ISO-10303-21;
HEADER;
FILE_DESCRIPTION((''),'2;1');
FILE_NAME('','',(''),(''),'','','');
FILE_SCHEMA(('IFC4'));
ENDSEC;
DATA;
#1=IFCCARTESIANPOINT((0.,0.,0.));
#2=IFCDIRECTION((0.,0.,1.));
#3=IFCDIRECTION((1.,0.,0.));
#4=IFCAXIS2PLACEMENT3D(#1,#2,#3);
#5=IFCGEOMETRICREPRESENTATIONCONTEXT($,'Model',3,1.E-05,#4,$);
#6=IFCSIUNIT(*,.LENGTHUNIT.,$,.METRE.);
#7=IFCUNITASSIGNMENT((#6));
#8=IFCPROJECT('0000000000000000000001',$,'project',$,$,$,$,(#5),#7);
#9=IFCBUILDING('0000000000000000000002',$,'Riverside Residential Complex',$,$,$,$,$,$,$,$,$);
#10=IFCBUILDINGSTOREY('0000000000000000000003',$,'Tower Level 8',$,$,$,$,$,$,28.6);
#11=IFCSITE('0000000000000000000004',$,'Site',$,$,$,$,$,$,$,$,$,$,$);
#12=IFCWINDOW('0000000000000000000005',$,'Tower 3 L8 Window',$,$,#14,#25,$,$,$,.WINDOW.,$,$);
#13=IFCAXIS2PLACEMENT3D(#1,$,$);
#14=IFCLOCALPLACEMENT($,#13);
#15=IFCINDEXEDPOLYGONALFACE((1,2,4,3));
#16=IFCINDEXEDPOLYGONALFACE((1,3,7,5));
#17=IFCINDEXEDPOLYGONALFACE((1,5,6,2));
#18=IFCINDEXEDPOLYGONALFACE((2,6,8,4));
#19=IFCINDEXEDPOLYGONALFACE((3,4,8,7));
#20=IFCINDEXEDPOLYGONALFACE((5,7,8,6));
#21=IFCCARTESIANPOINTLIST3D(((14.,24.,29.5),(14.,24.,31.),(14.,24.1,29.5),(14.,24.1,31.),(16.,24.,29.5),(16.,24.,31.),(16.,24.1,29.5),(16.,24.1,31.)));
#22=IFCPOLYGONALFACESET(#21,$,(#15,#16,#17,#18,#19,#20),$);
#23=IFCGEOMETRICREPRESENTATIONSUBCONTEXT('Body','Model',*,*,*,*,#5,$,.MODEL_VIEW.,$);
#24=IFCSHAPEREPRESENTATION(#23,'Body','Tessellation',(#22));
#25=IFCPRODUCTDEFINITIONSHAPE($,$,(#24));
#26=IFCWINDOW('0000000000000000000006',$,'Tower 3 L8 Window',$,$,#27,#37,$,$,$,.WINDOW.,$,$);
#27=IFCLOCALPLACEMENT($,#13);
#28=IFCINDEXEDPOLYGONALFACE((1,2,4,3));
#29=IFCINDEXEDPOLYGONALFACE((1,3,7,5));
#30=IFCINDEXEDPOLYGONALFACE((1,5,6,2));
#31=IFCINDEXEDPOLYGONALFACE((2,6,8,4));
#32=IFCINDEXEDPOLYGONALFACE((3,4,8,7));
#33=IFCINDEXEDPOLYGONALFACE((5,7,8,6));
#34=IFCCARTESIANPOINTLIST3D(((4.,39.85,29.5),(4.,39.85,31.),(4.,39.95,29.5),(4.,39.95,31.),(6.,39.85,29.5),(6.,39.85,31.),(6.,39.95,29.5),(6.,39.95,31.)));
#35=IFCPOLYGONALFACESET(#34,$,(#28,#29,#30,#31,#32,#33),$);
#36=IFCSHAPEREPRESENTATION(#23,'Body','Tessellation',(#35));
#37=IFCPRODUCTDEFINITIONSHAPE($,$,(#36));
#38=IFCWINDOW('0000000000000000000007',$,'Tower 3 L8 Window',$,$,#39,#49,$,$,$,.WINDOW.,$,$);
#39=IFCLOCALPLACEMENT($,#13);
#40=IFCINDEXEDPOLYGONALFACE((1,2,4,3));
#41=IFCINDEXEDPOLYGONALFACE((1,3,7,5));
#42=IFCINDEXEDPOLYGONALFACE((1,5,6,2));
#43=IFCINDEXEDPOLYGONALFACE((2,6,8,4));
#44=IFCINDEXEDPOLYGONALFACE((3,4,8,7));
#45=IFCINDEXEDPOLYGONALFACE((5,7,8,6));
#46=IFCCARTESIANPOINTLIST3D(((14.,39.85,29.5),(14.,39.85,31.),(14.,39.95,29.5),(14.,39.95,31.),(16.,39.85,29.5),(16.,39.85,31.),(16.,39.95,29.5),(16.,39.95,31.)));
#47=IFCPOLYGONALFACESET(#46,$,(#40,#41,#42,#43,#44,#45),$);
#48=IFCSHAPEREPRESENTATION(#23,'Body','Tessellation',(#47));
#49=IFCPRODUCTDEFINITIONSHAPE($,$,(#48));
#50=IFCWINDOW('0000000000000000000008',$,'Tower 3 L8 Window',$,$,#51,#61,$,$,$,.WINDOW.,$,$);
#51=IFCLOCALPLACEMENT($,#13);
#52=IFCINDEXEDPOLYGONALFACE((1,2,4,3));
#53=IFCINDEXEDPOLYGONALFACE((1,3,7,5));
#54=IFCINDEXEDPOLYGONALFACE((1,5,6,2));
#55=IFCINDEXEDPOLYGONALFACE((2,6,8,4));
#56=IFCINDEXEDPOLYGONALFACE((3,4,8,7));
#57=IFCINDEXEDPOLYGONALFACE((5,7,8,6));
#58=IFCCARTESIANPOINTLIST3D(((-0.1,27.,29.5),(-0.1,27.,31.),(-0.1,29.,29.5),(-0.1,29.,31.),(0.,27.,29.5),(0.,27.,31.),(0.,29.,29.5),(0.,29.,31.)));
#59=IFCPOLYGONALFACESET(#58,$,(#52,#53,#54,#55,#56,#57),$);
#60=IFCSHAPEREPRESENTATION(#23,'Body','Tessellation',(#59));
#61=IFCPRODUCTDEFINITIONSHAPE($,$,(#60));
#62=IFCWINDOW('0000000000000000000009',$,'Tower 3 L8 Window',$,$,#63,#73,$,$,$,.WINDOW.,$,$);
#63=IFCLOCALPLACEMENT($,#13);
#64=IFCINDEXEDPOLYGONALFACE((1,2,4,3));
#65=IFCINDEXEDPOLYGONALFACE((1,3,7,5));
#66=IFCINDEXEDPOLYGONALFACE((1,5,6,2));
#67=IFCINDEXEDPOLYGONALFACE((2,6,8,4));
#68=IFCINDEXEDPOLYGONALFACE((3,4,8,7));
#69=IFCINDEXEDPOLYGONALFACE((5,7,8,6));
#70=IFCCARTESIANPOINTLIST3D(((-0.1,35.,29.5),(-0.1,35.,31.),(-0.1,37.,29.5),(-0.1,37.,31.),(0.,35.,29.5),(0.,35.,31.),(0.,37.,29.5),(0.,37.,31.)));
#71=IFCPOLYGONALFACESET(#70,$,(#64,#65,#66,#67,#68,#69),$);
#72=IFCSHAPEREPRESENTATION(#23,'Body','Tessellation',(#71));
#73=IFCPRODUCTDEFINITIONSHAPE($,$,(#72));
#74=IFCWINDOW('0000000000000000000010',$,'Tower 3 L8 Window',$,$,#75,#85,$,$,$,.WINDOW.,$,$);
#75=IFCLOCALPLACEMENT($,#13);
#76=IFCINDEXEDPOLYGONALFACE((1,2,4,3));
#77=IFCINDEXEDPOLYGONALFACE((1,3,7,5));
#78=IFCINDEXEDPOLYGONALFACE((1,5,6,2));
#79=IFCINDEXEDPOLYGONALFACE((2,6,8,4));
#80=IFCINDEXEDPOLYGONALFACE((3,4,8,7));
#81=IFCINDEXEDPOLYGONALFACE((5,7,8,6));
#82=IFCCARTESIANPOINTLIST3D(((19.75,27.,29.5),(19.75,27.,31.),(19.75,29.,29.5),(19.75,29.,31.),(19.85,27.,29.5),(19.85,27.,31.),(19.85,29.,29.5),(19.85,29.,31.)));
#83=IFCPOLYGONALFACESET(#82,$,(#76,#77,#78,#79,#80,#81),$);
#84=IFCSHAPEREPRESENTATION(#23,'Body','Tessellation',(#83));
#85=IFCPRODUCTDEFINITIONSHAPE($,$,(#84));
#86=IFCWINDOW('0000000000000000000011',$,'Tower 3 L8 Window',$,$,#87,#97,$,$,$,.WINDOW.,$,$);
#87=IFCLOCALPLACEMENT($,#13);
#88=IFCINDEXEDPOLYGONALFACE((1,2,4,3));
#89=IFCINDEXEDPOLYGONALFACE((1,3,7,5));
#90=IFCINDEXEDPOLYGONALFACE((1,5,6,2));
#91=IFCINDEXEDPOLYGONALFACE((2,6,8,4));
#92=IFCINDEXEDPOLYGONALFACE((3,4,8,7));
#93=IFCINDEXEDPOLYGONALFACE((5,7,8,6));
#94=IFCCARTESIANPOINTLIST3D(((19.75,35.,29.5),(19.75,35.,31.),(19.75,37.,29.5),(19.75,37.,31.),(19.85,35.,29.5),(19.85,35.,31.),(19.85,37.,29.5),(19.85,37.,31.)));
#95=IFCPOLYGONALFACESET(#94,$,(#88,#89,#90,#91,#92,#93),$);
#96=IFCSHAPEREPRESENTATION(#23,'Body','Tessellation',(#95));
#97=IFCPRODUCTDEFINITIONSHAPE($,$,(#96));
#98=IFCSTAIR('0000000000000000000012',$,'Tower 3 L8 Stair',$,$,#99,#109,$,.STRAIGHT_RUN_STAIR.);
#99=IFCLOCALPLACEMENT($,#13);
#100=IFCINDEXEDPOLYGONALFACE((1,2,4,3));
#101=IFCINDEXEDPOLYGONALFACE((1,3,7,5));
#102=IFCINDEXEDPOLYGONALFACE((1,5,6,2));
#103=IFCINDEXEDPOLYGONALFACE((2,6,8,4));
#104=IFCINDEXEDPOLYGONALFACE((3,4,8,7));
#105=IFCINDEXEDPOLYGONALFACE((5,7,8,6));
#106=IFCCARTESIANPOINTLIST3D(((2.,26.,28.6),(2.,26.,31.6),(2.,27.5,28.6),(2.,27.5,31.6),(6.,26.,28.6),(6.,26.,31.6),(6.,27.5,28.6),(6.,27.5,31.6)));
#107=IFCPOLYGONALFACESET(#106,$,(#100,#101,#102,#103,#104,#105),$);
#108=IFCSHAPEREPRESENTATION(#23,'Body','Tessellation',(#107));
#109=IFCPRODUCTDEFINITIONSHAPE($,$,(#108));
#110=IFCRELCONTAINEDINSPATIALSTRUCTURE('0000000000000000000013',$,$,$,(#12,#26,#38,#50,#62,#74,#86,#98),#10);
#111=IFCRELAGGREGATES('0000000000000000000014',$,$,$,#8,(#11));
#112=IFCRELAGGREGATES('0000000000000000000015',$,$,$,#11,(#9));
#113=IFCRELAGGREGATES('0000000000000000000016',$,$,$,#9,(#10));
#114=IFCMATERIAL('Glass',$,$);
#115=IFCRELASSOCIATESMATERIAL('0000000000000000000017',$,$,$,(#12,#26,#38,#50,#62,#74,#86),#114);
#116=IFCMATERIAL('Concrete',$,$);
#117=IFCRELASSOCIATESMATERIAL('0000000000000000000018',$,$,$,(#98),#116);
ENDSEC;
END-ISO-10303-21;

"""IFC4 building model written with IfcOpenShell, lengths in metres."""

from ifc_helpers import new_model, si_unit, frame, origin_with_axes, place, context, subcontext, project, spatial, line, indexed_curve, outline, extrude, material, element, save


model = new_model("IFC4")

# Units and contexts
model_context = context("Model", 3, precision=1e-05, world=origin_with_axes())
body_context = subcontext(model_context, "Body", "Model", "MODEL_VIEW")
ifc_project = project(units=[si_unit("LENGTHUNIT", "METRE")], contexts=[model_context])

# Site, building, storey
site = spatial("IfcSite", under=ifc_project, Name="Site")
building = spatial("IfcBuilding", under=site, Name="Riverside Residential Complex")
storey = spatial("IfcBuildingStorey", under=building, Name="Tower Level 8", Elevation=28.6)

# Shared definitions
ifc_material_1 = material(Name="Concrete")

# Windows
ifc_material_2 = material(Name="Glass")
for number, where, z_axis, x_axis, name in (
    (1, (14.0, 24.0, 29.5), (0.0, 0.0, 1.0), (1.0, 0.0, 0.0), "Tower 3 L8 Window"),
    (2, (4.0, 39.85, 29.5), (0.0, 0.0, 1.0), (1.0, 0.0, 0.0), "Tower 3 L8 Window"),
    (3, (14.0, 39.85, 29.5), (0.0, 0.0, 1.0), (1.0, 0.0, 0.0), "Tower 3 L8 Window"),
    (4, (0.0, 27.0, 29.5), (0.0, 0.0, 1.0), (0.0, 1.0, 0.0), "Tower 3 L8 Window"),
    (5, (0.0, 35.0, 29.5), (0.0, 0.0, 1.0), (0.0, 1.0, 0.0), "Tower 3 L8 Window"),
    (6, (19.85, 27.0, 29.5), (0.0, 0.0, 1.0), (0.0, 1.0, 0.0), "Tower 3 L8 Window"),
    (7, (19.85, 35.0, 29.5), (0.0, 0.0, 1.0), (0.0, 1.0, 0.0), "Tower 3 L8 Window"),
):
    element("IfcWindow", number, at=place(None, frame(where, z_axis=z_axis, x_axis=x_axis)), inside=storey, material=ifc_material_2, Name=name, PredefinedType="WINDOW", context=body_context, shape_type="SweptSolid", body=[
        extrude(outline(indexed_curve([(0.0, 0.0), (2.0, 0.0), (2.0, 0.1), (0.0, 0.1)], segments=[line(1, 2, 3, 4, 1)])), origin_with_axes(), (0.0, 0.0, 1.0), 1.5),
    ])

# Stair
stair_placement = place(None, frame((2.0, 26.0, 28.6), z_axis=(0.0, 0.0, 1.0), x_axis=(1.0, 0.0, 0.0)))
element("IfcStair", 8, at=stair_placement, inside=storey, material=ifc_material_1, Name="Tower 3 L8 Stair", PredefinedType="STRAIGHT_RUN_STAIR", context=body_context, shape_type="SweptSolid", body=[
    extrude(outline(indexed_curve([(0.0, 0.0), (4.0, 0.0), (4.0, 1.5), (0.0, 1.5)], segments=[line(1, 2, 3, 4, 1)])), origin_with_axes(), (0.0, 0.0, 1.0), 3.0),
])

save(model, "model.ifc")
